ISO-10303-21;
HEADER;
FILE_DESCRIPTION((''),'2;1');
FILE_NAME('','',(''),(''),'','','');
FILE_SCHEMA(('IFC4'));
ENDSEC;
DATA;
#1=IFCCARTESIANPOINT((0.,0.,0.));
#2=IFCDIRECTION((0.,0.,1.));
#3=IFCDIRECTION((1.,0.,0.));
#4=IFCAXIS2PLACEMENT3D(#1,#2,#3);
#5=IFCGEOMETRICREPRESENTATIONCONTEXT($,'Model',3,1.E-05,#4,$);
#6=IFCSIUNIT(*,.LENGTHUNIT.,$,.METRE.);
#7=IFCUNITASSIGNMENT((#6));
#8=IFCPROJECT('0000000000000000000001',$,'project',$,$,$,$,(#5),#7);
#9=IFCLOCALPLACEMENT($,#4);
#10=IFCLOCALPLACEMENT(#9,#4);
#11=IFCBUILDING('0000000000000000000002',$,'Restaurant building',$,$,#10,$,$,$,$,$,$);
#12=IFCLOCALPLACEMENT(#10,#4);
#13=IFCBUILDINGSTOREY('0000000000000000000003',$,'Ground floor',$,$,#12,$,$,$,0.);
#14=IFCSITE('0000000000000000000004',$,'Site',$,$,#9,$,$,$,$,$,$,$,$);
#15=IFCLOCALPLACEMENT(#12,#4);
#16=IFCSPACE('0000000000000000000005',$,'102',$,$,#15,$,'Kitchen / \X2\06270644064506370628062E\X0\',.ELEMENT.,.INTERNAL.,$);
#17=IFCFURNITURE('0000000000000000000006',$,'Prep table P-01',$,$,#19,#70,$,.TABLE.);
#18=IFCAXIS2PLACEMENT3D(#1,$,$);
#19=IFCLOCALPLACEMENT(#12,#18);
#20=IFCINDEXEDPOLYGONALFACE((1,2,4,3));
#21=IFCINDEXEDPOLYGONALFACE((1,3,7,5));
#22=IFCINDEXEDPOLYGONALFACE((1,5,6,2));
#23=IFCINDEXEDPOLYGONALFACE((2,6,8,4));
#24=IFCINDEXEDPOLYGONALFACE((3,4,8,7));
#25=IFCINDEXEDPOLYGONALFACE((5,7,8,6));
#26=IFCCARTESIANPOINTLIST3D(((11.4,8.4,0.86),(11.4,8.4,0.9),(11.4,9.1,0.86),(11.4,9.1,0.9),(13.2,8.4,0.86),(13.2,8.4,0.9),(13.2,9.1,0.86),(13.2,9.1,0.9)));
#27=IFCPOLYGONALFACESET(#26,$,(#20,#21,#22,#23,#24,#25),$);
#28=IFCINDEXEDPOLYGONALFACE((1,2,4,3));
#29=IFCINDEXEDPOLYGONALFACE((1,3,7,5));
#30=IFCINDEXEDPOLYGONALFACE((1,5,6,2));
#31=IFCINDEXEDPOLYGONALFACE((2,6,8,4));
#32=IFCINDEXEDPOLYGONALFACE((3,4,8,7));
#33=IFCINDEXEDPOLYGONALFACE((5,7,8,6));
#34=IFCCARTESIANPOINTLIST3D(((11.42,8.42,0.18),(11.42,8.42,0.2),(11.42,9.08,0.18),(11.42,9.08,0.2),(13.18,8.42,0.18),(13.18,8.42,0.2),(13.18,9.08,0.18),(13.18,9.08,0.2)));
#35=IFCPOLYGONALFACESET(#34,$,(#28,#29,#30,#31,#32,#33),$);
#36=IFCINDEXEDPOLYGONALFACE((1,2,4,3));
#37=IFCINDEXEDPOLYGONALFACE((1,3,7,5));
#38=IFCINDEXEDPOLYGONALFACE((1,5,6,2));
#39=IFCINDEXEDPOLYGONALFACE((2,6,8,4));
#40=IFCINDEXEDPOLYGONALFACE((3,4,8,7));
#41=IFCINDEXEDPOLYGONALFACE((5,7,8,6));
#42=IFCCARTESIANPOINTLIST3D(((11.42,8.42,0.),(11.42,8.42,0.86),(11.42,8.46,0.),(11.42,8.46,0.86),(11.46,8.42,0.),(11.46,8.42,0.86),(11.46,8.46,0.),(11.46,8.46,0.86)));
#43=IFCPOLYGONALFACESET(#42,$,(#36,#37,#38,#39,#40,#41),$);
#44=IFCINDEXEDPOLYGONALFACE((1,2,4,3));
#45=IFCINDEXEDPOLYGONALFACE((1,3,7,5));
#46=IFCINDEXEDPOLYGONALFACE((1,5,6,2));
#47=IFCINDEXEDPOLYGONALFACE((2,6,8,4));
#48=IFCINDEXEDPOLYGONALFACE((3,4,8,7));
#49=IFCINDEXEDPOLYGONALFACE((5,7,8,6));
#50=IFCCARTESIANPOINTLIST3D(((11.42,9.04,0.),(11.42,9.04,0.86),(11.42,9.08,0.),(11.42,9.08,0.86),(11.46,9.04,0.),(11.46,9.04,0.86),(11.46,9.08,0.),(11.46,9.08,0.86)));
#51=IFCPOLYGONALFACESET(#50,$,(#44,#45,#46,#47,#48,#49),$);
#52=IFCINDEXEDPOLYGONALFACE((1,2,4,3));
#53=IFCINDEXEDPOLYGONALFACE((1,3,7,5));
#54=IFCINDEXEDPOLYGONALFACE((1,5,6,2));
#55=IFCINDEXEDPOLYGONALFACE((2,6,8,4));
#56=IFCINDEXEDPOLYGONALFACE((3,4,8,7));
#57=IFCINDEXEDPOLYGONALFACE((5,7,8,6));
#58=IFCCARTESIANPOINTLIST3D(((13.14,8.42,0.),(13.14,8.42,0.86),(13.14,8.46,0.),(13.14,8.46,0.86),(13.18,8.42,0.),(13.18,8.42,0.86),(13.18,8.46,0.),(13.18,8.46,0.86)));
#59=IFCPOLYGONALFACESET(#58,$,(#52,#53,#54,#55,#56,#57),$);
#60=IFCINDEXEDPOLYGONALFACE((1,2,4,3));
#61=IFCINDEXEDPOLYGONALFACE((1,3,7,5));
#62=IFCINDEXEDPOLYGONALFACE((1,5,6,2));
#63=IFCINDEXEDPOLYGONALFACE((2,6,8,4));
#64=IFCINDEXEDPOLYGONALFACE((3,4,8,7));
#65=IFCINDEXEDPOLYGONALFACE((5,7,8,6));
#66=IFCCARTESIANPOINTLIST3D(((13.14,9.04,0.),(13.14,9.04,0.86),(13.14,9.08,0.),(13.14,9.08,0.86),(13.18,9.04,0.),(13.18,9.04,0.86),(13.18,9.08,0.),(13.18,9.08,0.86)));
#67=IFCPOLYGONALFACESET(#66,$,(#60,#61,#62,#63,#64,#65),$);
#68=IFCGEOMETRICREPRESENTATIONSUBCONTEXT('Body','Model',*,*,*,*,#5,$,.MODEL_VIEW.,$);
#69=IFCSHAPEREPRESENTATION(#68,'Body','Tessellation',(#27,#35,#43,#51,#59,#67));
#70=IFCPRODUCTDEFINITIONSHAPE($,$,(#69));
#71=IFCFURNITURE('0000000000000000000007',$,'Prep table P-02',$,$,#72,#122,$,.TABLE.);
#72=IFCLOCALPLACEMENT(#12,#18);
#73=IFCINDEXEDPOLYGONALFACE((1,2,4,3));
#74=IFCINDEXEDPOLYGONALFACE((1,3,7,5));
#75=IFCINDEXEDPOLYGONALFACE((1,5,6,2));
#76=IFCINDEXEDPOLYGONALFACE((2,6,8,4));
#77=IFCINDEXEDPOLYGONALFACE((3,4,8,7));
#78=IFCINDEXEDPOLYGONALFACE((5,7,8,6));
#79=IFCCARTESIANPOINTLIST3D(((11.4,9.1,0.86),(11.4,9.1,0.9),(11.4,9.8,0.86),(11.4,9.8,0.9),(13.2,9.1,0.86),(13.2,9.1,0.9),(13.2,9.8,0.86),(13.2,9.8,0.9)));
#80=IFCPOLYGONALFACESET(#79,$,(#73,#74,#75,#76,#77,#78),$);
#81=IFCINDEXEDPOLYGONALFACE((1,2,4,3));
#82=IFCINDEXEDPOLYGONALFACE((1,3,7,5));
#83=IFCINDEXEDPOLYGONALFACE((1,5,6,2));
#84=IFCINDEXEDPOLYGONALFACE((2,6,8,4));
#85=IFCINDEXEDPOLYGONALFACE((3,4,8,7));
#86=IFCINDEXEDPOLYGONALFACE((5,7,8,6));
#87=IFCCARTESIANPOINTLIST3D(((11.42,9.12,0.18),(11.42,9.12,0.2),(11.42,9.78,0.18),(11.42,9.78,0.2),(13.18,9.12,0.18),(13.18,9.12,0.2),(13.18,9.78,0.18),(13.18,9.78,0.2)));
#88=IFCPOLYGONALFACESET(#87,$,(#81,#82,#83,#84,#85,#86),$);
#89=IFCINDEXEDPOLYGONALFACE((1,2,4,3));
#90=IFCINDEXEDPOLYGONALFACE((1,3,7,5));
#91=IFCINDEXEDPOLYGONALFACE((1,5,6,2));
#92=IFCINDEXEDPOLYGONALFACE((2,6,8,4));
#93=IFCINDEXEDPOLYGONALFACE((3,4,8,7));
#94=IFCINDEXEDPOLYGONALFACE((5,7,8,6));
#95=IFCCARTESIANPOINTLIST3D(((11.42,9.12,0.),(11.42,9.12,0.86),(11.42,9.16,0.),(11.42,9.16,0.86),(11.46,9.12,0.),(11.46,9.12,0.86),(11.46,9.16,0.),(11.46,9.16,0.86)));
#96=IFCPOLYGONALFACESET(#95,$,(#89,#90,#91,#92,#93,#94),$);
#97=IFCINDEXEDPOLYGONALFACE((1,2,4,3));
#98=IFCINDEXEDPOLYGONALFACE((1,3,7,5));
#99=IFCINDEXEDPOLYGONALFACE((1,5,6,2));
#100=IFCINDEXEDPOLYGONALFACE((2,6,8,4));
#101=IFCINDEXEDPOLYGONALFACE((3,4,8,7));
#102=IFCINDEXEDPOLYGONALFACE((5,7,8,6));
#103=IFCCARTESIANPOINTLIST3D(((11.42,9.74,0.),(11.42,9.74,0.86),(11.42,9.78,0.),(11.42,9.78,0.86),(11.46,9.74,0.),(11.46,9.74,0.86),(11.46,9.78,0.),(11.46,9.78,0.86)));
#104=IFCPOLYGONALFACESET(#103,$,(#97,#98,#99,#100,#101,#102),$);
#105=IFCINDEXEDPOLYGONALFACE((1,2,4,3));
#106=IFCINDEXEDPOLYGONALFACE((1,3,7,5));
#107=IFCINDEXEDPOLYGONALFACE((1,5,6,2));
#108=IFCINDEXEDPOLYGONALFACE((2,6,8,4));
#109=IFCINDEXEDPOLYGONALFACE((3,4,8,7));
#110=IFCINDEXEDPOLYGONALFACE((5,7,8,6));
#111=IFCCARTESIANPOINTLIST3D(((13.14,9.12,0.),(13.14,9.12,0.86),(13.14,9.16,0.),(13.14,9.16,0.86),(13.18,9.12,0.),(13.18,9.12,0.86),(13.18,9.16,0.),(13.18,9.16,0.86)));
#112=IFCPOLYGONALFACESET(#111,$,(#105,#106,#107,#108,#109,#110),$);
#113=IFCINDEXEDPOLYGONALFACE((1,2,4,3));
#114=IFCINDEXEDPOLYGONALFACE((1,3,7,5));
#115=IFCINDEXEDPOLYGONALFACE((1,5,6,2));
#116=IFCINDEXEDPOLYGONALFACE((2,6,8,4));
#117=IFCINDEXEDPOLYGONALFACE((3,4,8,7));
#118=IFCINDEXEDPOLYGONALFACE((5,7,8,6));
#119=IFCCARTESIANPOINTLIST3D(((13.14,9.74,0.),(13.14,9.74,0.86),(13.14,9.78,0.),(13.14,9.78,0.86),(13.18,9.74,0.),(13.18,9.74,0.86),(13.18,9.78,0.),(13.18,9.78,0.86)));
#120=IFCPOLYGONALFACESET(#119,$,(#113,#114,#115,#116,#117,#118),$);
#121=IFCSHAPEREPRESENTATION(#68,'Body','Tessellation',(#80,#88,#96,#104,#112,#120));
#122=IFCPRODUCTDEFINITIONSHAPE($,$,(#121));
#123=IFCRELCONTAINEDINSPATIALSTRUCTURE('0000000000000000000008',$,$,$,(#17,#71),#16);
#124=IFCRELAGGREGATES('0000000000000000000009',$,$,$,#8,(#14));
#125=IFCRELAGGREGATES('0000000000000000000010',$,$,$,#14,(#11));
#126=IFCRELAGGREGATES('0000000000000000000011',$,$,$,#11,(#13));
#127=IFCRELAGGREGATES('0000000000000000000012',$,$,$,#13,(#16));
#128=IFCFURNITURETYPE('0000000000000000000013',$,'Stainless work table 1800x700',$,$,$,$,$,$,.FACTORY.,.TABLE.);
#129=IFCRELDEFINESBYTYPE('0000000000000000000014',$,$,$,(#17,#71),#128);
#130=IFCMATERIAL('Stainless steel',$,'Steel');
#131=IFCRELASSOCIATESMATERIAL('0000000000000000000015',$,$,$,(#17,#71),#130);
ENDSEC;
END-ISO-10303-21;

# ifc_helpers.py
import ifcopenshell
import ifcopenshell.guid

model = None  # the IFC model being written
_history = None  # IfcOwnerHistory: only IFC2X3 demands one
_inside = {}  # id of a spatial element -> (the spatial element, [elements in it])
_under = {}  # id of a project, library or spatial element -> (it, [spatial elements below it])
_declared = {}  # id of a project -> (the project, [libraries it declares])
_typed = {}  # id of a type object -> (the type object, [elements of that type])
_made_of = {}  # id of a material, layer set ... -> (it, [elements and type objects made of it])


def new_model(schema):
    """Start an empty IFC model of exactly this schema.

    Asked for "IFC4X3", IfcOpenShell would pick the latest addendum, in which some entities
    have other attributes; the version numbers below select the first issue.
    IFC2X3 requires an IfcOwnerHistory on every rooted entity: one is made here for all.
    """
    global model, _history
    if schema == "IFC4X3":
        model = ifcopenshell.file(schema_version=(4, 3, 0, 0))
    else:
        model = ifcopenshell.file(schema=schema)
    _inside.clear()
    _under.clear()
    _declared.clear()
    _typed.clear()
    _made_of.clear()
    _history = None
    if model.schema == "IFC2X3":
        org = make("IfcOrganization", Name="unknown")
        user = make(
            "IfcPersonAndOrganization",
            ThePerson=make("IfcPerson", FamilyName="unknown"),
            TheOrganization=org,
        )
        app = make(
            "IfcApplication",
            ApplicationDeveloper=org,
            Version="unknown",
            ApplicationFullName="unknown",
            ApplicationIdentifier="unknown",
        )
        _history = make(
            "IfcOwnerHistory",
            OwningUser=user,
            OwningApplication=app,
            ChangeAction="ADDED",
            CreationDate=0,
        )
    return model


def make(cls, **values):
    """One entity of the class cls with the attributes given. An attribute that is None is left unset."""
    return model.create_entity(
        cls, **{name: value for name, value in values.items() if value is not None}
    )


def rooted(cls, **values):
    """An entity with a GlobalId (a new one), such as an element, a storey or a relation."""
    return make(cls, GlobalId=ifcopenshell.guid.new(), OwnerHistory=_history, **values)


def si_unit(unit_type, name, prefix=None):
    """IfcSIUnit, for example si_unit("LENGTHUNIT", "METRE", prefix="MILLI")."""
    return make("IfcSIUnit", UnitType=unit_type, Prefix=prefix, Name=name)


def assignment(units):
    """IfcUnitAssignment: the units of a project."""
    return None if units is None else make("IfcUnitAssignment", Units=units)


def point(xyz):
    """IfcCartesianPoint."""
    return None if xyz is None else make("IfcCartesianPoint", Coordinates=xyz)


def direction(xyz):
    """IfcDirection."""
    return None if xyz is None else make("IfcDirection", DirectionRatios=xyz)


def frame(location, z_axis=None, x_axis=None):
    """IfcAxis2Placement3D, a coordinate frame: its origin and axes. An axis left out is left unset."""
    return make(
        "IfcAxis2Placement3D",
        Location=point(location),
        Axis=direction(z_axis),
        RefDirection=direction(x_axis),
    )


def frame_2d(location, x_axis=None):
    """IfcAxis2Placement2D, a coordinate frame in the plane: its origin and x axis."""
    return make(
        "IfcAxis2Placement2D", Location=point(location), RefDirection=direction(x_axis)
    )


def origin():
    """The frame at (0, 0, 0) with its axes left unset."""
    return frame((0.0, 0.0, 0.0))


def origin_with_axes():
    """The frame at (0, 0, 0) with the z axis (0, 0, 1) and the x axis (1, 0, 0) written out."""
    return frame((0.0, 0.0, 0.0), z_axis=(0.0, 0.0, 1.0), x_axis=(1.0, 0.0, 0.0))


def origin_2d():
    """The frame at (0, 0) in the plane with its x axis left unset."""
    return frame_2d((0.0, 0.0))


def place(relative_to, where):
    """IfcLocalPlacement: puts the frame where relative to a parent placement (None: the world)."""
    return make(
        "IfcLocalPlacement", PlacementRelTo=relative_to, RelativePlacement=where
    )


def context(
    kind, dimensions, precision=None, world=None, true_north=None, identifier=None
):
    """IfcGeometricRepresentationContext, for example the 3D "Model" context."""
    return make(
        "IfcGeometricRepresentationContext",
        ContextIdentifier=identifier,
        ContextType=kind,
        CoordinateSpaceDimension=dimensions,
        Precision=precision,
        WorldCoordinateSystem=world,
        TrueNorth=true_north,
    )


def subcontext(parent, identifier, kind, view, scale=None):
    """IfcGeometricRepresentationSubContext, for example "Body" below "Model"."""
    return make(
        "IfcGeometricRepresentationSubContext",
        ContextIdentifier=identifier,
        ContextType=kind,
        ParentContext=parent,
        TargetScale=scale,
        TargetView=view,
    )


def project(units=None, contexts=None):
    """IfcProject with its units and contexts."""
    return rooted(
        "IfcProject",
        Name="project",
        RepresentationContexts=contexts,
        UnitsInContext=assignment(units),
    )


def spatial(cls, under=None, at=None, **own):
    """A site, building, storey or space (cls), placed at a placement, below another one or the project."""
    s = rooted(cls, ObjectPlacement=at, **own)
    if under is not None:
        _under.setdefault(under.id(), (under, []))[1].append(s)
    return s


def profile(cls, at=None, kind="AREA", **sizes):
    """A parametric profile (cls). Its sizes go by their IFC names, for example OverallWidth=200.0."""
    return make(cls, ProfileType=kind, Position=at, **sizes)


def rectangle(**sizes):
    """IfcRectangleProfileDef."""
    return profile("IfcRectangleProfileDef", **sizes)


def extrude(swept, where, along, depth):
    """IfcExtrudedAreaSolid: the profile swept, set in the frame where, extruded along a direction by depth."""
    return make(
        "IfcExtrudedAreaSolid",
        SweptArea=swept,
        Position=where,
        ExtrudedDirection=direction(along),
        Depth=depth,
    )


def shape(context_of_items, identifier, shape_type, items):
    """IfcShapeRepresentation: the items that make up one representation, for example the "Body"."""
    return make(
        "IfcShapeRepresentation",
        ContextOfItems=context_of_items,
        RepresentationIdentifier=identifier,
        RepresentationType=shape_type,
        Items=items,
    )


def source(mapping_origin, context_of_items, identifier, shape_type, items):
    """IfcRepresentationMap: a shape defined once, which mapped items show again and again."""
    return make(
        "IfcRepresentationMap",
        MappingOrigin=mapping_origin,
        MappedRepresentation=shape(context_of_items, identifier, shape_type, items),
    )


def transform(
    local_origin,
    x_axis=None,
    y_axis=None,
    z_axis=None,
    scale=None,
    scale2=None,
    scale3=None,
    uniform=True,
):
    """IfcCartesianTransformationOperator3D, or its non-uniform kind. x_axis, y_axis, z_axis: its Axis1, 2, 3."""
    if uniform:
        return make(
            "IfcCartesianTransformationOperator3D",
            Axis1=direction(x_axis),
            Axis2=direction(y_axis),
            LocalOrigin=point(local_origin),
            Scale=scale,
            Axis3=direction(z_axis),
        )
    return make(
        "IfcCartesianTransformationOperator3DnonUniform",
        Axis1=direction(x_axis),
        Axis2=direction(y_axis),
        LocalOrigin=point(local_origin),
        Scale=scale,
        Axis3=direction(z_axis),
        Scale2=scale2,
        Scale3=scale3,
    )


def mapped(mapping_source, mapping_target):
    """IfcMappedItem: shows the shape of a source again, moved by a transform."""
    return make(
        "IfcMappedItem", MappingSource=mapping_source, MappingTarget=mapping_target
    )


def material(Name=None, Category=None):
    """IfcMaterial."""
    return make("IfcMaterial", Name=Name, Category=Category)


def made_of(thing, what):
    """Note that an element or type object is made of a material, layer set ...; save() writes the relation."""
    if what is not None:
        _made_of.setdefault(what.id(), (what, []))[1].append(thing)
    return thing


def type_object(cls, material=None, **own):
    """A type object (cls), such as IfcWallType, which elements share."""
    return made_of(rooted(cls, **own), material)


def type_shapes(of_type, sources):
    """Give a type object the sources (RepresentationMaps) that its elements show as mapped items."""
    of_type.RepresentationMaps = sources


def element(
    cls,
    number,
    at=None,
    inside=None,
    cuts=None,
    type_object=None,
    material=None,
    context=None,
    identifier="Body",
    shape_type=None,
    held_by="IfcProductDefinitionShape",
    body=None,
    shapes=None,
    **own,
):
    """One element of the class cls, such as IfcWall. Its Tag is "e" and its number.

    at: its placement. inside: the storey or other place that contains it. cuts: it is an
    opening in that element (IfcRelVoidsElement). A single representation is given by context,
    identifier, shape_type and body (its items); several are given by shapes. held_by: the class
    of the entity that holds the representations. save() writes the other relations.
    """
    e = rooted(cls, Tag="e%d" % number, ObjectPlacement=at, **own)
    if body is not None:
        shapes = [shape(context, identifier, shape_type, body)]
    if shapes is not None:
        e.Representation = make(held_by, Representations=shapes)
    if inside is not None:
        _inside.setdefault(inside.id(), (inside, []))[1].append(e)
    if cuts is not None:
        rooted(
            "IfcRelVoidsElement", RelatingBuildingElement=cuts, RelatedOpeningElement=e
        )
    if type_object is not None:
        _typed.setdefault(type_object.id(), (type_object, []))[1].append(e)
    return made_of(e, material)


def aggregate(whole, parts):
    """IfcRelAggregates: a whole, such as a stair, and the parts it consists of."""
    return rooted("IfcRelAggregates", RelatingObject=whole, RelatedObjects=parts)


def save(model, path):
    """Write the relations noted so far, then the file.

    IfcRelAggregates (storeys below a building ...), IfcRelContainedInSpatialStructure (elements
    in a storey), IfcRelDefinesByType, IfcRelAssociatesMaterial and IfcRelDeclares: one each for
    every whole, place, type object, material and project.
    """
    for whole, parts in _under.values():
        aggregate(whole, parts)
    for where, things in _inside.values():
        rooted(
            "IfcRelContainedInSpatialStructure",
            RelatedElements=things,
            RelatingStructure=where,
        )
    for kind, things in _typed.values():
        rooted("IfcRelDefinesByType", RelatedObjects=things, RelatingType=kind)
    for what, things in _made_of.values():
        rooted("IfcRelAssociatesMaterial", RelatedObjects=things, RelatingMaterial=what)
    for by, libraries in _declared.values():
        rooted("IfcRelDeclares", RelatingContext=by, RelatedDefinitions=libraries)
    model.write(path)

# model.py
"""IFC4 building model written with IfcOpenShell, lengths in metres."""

from ifc_helpers import new_model, si_unit, frame, origin, origin_with_axes, origin_2d, place, context, subcontext, project, spatial, rectangle, extrude, source, transform, mapped, material, type_object, type_shapes, element, save


model = new_model("IFC4")

# Units and contexts
model_context = context("Model", 3, precision=1e-05, world=origin_with_axes())
body_context = subcontext(model_context, "Body", "Model", "MODEL_VIEW")
ifc_project = project(units=[si_unit("LENGTHUNIT", "METRE")], contexts=[model_context])

# Site, building, storey
site_placement = place(None, origin_with_axes())
site = spatial("IfcSite", under=ifc_project, at=site_placement, Name="Site")
building_placement = place(site_placement, origin_with_axes())
building = spatial("IfcBuilding", under=site, at=building_placement, Name="Restaurant building")
storey_placement = place(building_placement, origin_with_axes())
storey = spatial("IfcBuildingStorey", under=building, at=storey_placement, Name="Ground floor", Elevation=0.0)

# Shared definitions
space_placement = place(storey_placement, origin_with_axes())
space = spatial("IfcSpace", under=storey, at=space_placement, Name="102", LongName="Kitchen / المطبخ", CompositionType="ELEMENT", PredefinedType="INTERNAL")

# Shared definitions
ifc_material_1 = material(Name="Stainless steel", Category="Steel")

# Furniture
furniture_type = type_object("IfcFurnitureType", Name="Stainless work table 1800x700", AssemblyPlace="FACTORY", PredefinedType="TABLE")
shared_shape_1 = source(origin(), body_context, "Body", "SweptSolid", [
    extrude(rectangle(XDim=1.8, YDim=0.7, at=origin_2d()), frame((0.0, 0.0, 0.86)), (0.0, 0.0, 1.0), 0.04),
    extrude(rectangle(XDim=1.76, YDim=0.66, at=origin_2d()), frame((0.0, 0.0, 0.18)), (0.0, 0.0, 1.0), 0.02),
    extrude(rectangle(XDim=0.04, YDim=0.04, at=origin_2d()), frame((-0.86, -0.31, 0.0)), (0.0, 0.0, 1.0), 0.86),
    extrude(rectangle(XDim=0.04, YDim=0.04, at=origin_2d()), frame((-0.86, 0.31, 0.0)), (0.0, 0.0, 1.0), 0.86),
    extrude(rectangle(XDim=0.04, YDim=0.04, at=origin_2d()), frame((0.86, -0.31, 0.0)), (0.0, 0.0, 1.0), 0.86),
    extrude(rectangle(XDim=0.04, YDim=0.04, at=origin_2d()), frame((0.86, 0.31, 0.0)), (0.0, 0.0, 1.0), 0.86),
])
type_shapes(furniture_type, [shared_shape_1])
for number, where, name in (
    (1, (12.3, 8.75, 0.0), "Prep table P-01"),
    (2, (12.3, 9.45, 0.0), "Prep table P-02"),
):
    element("IfcFurniture", number, at=place(storey_placement, frame(where)), inside=space, type_object=furniture_type, material=ifc_material_1, Name=name, PredefinedType="TABLE", context=body_context, shape_type="MappedRepresentation", body=[
        mapped(shared_shape_1, transform((0.0, 0.0, 0.0))),
    ])

save(model, "model.ifc")
